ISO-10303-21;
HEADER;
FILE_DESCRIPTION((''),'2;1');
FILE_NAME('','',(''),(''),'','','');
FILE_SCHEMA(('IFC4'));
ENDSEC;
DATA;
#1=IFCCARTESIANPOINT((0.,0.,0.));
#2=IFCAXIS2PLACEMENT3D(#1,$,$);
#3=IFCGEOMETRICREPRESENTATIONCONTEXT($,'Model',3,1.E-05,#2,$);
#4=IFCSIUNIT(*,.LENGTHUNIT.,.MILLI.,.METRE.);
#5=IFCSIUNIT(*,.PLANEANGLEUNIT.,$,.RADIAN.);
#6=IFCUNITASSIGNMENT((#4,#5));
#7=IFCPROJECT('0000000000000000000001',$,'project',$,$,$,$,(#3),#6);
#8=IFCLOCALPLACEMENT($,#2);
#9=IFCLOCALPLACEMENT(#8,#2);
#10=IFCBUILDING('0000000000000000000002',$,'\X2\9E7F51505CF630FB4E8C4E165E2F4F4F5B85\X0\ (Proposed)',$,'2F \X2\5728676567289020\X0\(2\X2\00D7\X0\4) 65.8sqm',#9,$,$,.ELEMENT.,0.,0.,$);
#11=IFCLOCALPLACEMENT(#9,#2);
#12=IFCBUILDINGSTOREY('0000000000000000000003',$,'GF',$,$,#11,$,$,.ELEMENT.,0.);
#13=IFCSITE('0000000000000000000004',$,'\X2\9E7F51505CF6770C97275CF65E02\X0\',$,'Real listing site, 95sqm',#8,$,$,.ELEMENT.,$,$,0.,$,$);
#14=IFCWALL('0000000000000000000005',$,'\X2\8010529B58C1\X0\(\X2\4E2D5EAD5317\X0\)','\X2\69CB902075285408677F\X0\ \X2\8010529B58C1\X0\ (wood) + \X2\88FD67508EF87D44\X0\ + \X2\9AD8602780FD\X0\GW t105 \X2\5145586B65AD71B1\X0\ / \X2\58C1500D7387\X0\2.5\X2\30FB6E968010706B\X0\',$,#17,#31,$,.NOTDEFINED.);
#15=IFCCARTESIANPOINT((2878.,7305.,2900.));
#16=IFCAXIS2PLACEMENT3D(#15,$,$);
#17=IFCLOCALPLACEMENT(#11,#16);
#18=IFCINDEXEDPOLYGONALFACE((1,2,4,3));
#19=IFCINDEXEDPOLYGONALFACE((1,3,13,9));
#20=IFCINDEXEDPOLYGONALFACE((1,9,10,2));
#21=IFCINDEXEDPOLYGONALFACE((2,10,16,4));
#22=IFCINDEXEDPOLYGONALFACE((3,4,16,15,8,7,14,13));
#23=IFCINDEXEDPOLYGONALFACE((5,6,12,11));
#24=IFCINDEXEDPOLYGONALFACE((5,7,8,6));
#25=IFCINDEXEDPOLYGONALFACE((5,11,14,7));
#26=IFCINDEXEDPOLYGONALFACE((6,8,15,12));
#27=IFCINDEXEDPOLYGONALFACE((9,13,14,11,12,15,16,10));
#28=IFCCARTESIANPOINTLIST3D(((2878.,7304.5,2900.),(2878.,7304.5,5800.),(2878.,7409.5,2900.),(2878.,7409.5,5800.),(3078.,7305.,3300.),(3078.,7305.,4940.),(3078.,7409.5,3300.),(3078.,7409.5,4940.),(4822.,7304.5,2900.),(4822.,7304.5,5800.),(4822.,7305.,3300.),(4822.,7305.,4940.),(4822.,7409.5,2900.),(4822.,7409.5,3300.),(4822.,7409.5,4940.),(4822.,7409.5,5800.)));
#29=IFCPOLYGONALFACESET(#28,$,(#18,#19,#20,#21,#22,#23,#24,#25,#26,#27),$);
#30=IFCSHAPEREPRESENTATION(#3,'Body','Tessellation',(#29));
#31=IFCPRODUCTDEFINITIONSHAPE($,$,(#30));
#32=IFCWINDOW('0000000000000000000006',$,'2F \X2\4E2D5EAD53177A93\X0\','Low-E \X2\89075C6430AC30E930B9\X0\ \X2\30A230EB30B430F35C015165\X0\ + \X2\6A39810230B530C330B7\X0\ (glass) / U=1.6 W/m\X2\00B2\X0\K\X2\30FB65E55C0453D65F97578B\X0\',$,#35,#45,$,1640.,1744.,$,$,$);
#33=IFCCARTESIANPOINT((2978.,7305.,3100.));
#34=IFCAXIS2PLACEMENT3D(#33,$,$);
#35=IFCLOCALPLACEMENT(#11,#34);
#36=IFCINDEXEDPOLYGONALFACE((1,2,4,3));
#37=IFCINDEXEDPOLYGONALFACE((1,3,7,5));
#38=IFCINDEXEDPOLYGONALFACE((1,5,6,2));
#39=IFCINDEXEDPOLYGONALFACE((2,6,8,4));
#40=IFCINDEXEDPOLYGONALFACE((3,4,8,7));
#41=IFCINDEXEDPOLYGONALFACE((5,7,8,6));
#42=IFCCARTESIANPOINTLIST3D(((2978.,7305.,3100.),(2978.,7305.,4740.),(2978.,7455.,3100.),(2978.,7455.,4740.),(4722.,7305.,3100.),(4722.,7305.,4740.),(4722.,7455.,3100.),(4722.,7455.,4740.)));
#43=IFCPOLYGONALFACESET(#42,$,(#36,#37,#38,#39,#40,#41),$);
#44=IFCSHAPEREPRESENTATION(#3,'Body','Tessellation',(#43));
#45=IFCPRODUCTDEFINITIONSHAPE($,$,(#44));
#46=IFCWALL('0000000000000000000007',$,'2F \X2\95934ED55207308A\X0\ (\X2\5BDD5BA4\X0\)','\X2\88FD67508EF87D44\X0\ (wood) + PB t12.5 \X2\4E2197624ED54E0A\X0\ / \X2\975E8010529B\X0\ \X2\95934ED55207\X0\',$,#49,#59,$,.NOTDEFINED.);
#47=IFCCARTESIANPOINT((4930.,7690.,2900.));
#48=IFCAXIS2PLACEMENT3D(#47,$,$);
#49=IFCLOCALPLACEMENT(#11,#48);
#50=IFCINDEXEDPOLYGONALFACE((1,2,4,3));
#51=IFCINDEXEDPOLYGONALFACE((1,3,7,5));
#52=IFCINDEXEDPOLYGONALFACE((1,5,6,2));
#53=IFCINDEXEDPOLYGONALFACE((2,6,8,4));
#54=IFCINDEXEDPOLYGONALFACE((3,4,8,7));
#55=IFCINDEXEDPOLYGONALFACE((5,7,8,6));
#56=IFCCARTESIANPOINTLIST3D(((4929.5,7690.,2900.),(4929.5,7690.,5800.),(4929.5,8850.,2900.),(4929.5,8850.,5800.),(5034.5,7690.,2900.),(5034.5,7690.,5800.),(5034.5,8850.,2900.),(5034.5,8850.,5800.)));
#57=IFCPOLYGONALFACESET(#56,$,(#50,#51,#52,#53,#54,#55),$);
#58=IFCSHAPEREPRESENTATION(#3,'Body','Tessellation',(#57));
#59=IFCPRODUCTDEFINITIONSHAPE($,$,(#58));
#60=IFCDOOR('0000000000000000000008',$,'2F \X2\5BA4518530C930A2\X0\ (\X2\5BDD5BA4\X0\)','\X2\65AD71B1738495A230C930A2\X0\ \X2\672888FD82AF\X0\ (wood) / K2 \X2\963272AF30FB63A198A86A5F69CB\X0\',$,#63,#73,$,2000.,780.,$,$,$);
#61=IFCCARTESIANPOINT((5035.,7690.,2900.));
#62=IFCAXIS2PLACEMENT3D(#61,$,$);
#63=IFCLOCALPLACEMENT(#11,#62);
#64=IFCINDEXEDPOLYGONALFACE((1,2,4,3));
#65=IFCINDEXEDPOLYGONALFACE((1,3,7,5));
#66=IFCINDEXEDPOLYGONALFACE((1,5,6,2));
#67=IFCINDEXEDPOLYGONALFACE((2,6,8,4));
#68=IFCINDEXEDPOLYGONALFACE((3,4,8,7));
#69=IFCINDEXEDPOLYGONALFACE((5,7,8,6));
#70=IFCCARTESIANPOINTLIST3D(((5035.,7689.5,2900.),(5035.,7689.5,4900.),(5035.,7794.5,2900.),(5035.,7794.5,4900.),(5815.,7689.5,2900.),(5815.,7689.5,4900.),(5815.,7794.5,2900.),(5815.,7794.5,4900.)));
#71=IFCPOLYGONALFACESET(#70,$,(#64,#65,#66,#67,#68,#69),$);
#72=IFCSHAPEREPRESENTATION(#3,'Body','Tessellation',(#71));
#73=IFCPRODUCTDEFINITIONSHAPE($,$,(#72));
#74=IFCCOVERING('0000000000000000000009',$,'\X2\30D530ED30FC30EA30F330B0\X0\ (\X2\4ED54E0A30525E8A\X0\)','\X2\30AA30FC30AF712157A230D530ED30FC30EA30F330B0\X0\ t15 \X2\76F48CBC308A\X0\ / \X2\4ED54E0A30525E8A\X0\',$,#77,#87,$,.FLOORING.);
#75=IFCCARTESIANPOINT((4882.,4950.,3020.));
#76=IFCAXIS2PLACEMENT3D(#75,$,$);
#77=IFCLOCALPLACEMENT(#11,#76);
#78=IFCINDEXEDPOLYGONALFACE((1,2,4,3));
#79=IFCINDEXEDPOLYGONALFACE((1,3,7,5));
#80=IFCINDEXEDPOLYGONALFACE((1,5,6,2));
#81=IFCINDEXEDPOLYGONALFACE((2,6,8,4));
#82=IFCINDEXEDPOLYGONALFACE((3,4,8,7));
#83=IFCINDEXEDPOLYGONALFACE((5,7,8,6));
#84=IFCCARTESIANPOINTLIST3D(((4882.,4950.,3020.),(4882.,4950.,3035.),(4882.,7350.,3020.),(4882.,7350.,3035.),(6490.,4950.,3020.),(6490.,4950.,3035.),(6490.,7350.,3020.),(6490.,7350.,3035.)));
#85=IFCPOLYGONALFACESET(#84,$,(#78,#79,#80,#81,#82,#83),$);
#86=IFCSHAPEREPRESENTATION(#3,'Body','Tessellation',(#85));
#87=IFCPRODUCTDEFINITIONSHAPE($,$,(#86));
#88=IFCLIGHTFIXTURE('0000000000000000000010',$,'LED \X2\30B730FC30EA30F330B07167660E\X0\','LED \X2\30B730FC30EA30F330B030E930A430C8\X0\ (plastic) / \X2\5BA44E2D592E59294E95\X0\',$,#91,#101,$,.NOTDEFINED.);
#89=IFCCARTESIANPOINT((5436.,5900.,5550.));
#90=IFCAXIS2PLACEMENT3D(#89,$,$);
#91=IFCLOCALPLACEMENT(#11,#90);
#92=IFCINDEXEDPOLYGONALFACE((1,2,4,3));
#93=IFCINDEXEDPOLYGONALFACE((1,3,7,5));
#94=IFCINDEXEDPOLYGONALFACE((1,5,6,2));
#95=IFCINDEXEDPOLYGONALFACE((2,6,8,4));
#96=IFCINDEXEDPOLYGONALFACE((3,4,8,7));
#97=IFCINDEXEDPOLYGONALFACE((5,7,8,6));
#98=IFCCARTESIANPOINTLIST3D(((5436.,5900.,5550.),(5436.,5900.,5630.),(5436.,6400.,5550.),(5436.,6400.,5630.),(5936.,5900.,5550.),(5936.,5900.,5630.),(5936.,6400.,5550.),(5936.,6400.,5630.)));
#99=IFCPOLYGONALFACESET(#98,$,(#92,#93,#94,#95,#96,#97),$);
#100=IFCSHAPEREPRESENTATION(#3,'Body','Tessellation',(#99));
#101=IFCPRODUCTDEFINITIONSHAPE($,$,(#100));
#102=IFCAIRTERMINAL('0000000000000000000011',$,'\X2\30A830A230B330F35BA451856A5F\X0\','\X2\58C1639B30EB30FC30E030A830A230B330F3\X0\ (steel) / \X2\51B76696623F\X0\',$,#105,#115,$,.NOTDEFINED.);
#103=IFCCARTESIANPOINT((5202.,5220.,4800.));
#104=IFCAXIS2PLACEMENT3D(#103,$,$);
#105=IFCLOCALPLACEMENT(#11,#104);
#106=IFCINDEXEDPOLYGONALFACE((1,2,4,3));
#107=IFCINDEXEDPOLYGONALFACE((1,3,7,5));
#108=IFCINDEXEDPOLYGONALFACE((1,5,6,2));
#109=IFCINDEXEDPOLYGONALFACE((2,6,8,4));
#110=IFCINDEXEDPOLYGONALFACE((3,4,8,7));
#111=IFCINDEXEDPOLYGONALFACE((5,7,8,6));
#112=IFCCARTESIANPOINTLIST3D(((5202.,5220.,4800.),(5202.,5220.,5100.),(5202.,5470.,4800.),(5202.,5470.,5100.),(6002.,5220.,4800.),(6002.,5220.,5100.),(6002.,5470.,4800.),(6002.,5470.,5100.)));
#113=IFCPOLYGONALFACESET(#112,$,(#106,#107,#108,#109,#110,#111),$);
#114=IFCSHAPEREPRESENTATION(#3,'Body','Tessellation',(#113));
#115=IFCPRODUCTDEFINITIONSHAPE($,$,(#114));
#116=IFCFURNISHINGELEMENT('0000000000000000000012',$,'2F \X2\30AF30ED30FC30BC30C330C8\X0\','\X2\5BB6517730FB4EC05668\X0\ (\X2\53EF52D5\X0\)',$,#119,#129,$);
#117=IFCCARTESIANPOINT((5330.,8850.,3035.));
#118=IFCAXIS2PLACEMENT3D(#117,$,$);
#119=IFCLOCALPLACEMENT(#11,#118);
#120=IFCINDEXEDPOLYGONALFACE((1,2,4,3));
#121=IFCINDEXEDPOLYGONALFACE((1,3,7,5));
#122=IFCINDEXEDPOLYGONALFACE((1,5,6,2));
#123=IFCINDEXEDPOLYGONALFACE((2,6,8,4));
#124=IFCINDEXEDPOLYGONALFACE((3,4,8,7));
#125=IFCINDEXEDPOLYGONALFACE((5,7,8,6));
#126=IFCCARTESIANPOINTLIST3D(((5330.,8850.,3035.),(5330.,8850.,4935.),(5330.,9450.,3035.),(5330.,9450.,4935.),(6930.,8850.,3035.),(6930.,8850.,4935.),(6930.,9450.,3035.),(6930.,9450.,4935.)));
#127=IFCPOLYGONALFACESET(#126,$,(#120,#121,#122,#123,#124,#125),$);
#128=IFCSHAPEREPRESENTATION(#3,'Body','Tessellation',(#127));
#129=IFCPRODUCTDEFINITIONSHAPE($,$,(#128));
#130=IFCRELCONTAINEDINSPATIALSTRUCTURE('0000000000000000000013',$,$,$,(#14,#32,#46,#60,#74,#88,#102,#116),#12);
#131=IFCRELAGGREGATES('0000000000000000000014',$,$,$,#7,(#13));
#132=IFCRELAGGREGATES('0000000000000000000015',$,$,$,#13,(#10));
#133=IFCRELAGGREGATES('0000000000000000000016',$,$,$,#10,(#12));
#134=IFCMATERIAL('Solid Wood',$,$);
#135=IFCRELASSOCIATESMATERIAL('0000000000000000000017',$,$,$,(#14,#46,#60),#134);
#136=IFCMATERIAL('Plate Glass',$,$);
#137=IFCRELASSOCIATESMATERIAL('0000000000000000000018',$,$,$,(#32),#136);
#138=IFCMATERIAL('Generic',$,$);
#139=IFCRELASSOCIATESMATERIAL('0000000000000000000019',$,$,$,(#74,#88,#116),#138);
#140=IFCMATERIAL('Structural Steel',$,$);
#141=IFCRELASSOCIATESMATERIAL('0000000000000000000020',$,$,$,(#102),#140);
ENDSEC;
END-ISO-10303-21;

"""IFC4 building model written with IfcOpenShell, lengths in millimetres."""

from ifc_helpers import new_model, si_unit, frame, frame_2d, origin, place, context, project, spatial, rectangle, extrude, material, element, fill, save


model = new_model("IFC4")

# Units and contexts
model_context = context("Model", 3, precision=1e-05, world=origin())
ifc_project = project(units=[si_unit("LENGTHUNIT", "METRE", prefix="MILLI"), si_unit("PLANEANGLEUNIT", "RADIAN")], contexts=[model_context])

# Site, building, storey
site_placement = place(None, origin())
site = spatial("IfcSite", under=ifc_project, at=site_placement, Name="鹿児島県霧島市", ObjectType="Real listing site, 95sqm", CompositionType="ELEMENT", RefElevation=0.0)
building_placement = place(site_placement, origin())
building = spatial("IfcBuilding", under=site, at=building_placement, Name="鹿児島・二世帯住宅 (Proposed)", ObjectType="2F 在来木造(2×4) 65.8sqm", CompositionType="ELEMENT", ElevationOfRefHeight=0.0, ElevationOfTerrain=0.0)
storey_placement = place(building_placement, origin())
storey = spatial("IfcBuildingStorey", under=building, at=storey_placement, Name="GF", CompositionType="ELEMENT", Elevation=0.0)

# Shared definitions
ifc_material_1 = material(Name="Solid Wood")

# Wall, opening, window
wall_1_placement = place(storey_placement, frame((2878.0, 7305.0, 2900.0)))
wall_1 = element("IfcWall", 1, at=wall_1_placement, inside=storey, material=ifc_material_1, Name="耐力壁(中庭北)", Description="構造用合板 耐力壁 (wood) + 製材軸組 + 高性能GW t105 充填断熱 / 壁倍率2.5・準耐火", PredefinedType="NOTDEFINED", context=model_context, shape_type="SweptSolid", body=[
    extrude(rectangle(XDim=1944.0, YDim=105.0, at=frame_2d((972.0, 52.0))), frame((2878.0, 7305.0, 2900.0)), (0.0, 0.0, 1.0), 2900.0),
])
opening_placement = place(storey_placement, frame((2978.0, 7305.0, 3100.0)))
opening = element("IfcOpeningElement", 2, at=opening_placement, cuts=wall_1, PredefinedType="NOTDEFINED", context=model_context, shape_type="SweptSolid", body=[
    extrude(rectangle(XDim=1744.0, YDim=150.0, at=frame_2d((872.0, 75.0))), frame((2978.0, 7305.0, 3100.0)), (0.0, 0.0, 1.0), 1640.0),
])
ifc_material_2 = material(Name="Plate Glass")
window_placement = place(storey_placement, frame((2978.0, 7305.0, 3100.0)))
window = element("IfcWindow", 3, at=window_placement, inside=storey, material=ifc_material_2, Name="2F 中庭北窓", Description="Low-E 複層ガラス アルゴン封入 + 樹脂サッシ (glass) / U=1.6 W/m²K・日射取得型", OverallHeight=1640.0, OverallWidth=1744.0, context=model_context, shape_type="SweptSolid", body=[
    extrude(rectangle(XDim=1744.0, YDim=150.0, at=frame_2d((872.0, 75.0))), frame((2978.0, 7305.0, 3100.0)), (0.0, 0.0, 1.0), 1640.0),
])
fill(opening, window)

# Wall
wall_2_placement = place(storey_placement, frame((4930.0, 7690.0, 2900.0)))
element("IfcWall", 4, at=wall_2_placement, inside=storey, material=ifc_material_1, Name="2F 間仕切り (寝室)", Description="製材軸組 (wood) + PB t12.5 両面仕上 / 非耐力 間仕切", PredefinedType="NOTDEFINED", context=model_context, shape_type="SweptSolid", body=[
    extrude(rectangle(XDim=105.0, YDim=1160.0, at=frame_2d((52.0, 580.0))), frame((4930.0, 7690.0, 2900.0)), (0.0, 0.0, 1.0), 2900.0),
])

# Door
door_placement = place(storey_placement, frame((5035.0, 7690.0, 2900.0)))
element("IfcDoor", 5, at=door_placement, inside=storey, material=ifc_material_1, Name="2F 室内ドア (寝室)", Description="断熱玄関ドア 木製芯 (wood) / K2 防犯・採風機構", OverallHeight=2000.0, OverallWidth=780.0, context=model_context, shape_type="SweptSolid", body=[
    extrude(rectangle(XDim=780.0, YDim=105.0, at=frame_2d((390.0, 52.0))), frame((5035.0, 7690.0, 2900.0)), (0.0, 0.0, 1.0), 2000.0),
])

# Covering
ifc_material_3 = material(Name="Generic")
covering_placement = place(storey_placement, frame((4882.0, 4950.0, 3020.0)))
element("IfcCovering", 6, at=covering_placement, inside=storey, material=ifc_material_3, Name="フローリング (仕上げ床)", Description="オーク無垢フローリング t15 直貼り / 仕上げ床", PredefinedType="FLOORING", context=model_context, shape_type="SweptSolid", body=[
    extrude(rectangle(XDim=1608.0, YDim=2400.0, at=frame_2d((804.0, 1200.0))), frame((4882.0, 4950.0, 3020.0)), (0.0, 0.0, 1.0), 15.0),
])

# Light fixture
light_fixture_placement = place(storey_placement, frame((5436.0, 5900.0, 5550.0)))
element("IfcLightFixture", 7, at=light_fixture_placement, inside=storey, material=ifc_material_3, Name="LED シーリング照明", Description="LED シーリングライト (plastic) / 室中央天井", PredefinedType="NOTDEFINED", context=model_context, shape_type="SweptSolid", body=[
    extrude(rectangle(XDim=500.0, YDim=500.0, at=frame_2d((250.0, 250.0))), frame((5436.0, 5900.0, 5550.0)), (0.0, 0.0, 1.0), 80.0),
])

# Air terminal
ifc_material_4 = material(Name="Structural Steel")
air_terminal_placement = place(storey_placement, frame((5202.0, 5220.0, 4800.0)))
element("IfcAirTerminal", 8, at=air_terminal_placement, inside=storey, material=ifc_material_4, Name="エアコン室内機", Description="壁掛ルームエアコン (steel) / 冷暖房", PredefinedType="NOTDEFINED", context=model_context, shape_type="SweptSolid", body=[
    extrude(rectangle(XDim=800.0, YDim=250.0, at=frame_2d((400.0, 125.0))), frame((5202.0, 5220.0, 4800.0)), (0.0, 0.0, 1.0), 300.0),
])

# Furnishing element
furnishing_placement = place(storey_placement, frame((5330.0, 8850.0, 3035.0)))
element("IfcFurnishingElement", 9, at=furnishing_placement, inside=storey, material=ifc_material_3, Name="2F クローゼット", Description="家具・什器 (可動)", context=model_context, shape_type="SweptSolid", body=[
    extrude(rectangle(XDim=1600.0, YDim=600.0, at=frame_2d((800.0, 300.0))), frame((5330.0, 8850.0, 3035.0)), (0.0, 0.0, 1.0), 1900.0),
])

save(model, "model.ifc")
